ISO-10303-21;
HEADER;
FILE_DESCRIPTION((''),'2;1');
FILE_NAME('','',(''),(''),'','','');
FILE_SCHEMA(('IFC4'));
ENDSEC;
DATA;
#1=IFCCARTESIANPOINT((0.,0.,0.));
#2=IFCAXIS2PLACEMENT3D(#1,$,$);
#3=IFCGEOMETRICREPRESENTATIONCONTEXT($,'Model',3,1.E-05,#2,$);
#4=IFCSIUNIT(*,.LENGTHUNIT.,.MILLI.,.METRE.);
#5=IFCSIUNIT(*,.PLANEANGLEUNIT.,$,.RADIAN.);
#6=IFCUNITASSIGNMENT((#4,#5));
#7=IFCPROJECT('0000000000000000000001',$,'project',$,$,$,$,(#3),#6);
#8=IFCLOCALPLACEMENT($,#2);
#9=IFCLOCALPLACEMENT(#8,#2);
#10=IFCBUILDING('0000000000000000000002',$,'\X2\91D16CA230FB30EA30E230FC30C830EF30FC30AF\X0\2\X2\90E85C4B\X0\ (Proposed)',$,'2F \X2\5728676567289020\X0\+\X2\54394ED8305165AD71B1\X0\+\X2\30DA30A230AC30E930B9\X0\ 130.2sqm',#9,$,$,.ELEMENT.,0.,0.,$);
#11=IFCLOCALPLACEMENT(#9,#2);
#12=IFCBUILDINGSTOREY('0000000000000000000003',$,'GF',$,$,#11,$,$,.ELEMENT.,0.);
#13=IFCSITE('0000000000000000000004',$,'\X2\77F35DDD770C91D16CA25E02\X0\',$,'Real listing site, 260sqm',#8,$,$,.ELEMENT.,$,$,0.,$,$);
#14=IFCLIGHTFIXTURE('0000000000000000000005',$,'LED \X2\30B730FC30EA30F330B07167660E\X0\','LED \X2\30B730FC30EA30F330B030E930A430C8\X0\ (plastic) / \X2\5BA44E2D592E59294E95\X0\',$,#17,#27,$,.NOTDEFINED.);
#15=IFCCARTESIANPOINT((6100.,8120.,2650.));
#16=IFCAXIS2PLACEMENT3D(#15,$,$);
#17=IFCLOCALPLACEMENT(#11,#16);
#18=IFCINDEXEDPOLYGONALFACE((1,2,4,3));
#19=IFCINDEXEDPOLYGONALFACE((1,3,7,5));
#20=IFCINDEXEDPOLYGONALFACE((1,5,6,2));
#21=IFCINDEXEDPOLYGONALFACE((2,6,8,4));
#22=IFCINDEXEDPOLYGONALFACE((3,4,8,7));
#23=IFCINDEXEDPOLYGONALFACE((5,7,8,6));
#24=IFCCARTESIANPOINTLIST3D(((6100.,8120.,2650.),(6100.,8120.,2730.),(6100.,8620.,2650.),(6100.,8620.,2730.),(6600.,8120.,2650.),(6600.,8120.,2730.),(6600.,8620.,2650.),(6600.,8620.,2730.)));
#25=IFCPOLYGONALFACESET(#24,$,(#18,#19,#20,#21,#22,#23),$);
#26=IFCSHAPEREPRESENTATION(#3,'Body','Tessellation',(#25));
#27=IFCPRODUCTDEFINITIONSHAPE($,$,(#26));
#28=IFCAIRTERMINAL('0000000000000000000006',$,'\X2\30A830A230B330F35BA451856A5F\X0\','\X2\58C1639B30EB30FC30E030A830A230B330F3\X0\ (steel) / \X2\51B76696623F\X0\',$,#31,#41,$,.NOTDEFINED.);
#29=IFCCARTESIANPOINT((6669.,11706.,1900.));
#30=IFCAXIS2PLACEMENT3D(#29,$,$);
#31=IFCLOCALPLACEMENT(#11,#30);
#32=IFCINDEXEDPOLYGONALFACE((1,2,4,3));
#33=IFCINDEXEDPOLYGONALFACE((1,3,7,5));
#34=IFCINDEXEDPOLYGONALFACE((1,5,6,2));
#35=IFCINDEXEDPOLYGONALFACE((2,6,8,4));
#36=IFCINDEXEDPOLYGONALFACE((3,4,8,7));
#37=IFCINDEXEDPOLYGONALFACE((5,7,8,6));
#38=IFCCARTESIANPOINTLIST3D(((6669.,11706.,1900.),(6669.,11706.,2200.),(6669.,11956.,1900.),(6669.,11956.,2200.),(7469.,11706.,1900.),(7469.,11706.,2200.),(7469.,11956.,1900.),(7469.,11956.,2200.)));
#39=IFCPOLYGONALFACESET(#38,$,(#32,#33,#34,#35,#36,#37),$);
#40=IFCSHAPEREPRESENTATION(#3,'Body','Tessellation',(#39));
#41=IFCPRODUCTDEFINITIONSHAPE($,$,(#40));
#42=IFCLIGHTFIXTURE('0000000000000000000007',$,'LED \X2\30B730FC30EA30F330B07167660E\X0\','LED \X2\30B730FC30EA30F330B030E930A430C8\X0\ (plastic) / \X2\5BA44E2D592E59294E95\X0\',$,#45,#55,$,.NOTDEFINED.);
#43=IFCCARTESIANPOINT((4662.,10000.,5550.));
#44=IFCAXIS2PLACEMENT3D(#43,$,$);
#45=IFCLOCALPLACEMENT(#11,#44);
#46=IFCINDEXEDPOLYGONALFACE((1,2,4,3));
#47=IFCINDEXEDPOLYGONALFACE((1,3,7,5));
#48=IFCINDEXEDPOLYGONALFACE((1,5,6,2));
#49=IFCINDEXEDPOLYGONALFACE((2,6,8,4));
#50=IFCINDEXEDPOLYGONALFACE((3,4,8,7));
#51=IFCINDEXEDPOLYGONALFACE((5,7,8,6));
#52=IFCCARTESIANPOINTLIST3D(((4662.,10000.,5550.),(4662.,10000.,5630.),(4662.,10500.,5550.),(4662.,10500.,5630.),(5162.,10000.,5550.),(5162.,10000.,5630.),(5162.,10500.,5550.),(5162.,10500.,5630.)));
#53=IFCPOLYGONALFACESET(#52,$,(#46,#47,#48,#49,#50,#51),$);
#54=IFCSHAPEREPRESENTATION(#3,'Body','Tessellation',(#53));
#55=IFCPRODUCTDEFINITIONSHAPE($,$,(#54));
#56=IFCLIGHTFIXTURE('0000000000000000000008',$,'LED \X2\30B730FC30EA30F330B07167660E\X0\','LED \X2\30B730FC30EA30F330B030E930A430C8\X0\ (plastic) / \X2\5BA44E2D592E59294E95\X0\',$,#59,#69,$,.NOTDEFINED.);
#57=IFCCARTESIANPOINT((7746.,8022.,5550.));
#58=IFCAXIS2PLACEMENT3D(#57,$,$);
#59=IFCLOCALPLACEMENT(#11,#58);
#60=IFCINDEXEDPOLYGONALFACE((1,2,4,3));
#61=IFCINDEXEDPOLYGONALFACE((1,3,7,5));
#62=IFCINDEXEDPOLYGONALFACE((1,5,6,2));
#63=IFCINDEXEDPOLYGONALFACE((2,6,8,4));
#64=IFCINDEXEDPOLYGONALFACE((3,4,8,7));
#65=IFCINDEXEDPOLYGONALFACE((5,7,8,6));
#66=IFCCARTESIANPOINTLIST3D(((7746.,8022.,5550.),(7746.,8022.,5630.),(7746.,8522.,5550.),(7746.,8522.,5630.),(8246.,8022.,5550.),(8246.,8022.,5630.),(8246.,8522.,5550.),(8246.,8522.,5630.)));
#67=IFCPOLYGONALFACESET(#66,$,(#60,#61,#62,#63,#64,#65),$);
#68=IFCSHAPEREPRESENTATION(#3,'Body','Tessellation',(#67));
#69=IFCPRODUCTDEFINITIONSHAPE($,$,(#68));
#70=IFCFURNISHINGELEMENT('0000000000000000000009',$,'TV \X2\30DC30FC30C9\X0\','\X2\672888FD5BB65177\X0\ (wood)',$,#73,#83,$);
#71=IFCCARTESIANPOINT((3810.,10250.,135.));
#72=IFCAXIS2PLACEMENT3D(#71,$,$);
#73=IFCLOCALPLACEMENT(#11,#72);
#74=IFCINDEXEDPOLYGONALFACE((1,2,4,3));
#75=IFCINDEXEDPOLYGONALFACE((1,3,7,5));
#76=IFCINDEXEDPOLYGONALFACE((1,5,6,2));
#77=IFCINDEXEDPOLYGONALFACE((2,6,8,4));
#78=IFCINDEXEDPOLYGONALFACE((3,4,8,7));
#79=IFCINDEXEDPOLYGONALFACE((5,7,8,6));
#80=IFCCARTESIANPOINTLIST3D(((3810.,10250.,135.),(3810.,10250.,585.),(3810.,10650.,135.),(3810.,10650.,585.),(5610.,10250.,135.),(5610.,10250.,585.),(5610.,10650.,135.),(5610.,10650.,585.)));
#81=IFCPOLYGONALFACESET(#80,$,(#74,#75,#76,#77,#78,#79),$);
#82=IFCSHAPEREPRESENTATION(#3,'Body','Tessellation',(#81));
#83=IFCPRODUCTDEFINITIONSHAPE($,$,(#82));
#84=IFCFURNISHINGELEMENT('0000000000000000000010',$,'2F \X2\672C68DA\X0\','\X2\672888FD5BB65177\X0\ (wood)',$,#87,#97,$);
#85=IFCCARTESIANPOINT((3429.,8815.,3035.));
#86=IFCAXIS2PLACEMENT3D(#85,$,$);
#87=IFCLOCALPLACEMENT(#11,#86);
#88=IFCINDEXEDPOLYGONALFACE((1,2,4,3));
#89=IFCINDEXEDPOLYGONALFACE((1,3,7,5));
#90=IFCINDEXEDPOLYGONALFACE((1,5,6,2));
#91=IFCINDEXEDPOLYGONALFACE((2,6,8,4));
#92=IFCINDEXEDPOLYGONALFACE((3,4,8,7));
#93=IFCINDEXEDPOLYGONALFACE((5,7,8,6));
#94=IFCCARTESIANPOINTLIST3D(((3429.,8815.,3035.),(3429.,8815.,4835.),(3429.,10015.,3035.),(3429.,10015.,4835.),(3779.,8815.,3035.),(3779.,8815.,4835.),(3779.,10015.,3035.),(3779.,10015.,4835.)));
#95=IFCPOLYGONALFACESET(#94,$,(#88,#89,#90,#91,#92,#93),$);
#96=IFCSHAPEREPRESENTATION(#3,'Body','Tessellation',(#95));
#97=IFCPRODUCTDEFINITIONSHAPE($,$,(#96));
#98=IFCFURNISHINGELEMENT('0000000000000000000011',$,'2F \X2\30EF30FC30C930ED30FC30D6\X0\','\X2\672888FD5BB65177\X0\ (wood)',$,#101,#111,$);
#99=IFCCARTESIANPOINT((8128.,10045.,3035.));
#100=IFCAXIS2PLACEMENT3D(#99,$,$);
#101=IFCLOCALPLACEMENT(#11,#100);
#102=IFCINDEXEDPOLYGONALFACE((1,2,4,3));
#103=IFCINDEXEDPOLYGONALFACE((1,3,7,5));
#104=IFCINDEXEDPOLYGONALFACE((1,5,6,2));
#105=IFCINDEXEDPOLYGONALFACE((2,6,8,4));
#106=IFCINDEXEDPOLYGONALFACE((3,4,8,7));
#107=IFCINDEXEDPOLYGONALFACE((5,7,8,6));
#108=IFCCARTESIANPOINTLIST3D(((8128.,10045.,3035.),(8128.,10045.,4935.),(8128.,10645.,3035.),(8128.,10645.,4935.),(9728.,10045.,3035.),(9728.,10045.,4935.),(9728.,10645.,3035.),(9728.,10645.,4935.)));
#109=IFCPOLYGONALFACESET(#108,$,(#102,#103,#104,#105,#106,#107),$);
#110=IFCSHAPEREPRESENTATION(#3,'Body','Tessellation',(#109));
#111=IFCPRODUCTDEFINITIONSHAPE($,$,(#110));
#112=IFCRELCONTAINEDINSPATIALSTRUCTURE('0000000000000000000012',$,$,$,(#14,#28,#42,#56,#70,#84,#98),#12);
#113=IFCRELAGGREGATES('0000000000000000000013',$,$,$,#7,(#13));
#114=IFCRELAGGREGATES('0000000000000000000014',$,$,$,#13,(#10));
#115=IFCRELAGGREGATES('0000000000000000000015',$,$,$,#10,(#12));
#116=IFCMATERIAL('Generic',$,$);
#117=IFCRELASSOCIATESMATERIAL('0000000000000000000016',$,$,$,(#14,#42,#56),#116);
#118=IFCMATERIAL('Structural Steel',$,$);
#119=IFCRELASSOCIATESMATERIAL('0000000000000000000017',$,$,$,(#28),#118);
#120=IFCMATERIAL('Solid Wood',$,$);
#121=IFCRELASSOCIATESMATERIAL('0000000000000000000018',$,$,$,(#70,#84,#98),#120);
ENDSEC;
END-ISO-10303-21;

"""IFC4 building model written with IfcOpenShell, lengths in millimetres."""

from ifc_helpers import new_model, si_unit, frame, frame_2d, origin, place, context, project, spatial, rectangle, extrude, material, element, save


model = new_model("IFC4")

# Units and contexts
model_context = context("Model", 3, precision=1e-05, world=origin())
ifc_project = project(units=[si_unit("LENGTHUNIT", "METRE", prefix="MILLI"), si_unit("PLANEANGLEUNIT", "RADIAN")], contexts=[model_context])

# Site, building, storey
site_placement = place(None, origin())
site = spatial("IfcSite", under=ifc_project, at=site_placement, Name="石川県金沢市", ObjectType="Real listing site, 260sqm", CompositionType="ELEMENT", RefElevation=0.0)
building_placement = place(site_placement, origin())
building = spatial("IfcBuilding", under=site, at=building_placement, Name="金沢・リモートワーク2部屋 (Proposed)", ObjectType="2F 在来木造+吹付け断熱+ペアガラス 130.2sqm", CompositionType="ELEMENT", ElevationOfRefHeight=0.0, ElevationOfTerrain=0.0)
storey_placement = place(building_placement, origin())
storey = spatial("IfcBuildingStorey", under=building, at=storey_placement, Name="GF", CompositionType="ELEMENT", Elevation=0.0)

# Shared definitions
ifc_material_1 = material(Name="Solid Wood")

# Shared definitions
ifc_material_2 = material(Name="Structural Steel")

# Shared definitions
ifc_material_3 = material(Name="Generic")

# Light fixture
light_fixture_1_placement = place(storey_placement, frame((6100.0, 8120.0, 2650.0)))
element("IfcLightFixture", 1, at=light_fixture_1_placement, inside=storey, material=ifc_material_3, Name="LED シーリング照明", Description="LED シーリングライト (plastic) / 室中央天井", PredefinedType="NOTDEFINED", context=model_context, shape_type="SweptSolid", body=[
    extrude(rectangle(XDim=500.0, YDim=500.0, at=frame_2d((250.0, 250.0))), frame((6100.0, 8120.0, 2650.0)), (0.0, 0.0, 1.0), 80.0),
])

# Air terminal
air_terminal_placement = place(storey_placement, frame((6669.0, 11706.0, 1900.0)))
element("IfcAirTerminal", 2, at=air_terminal_placement, inside=storey, material=ifc_material_2, Name="エアコン室内機", Description="壁掛ルームエアコン (steel) / 冷暖房", PredefinedType="NOTDEFINED", context=model_context, shape_type="SweptSolid", body=[
    extrude(rectangle(XDim=800.0, YDim=250.0, at=frame_2d((400.0, 125.0))), frame((6669.0, 11706.0, 1900.0)), (0.0, 0.0, 1.0), 300.0),
])

# Light fixtures
light_fixture_2_placement = place(storey_placement, frame((4662.0, 10000.0, 5550.0)))
element("IfcLightFixture", 3, at=light_fixture_2_placement, inside=storey, material=ifc_material_3, Name="LED シーリング照明", Description="LED シーリングライト (plastic) / 室中央天井", PredefinedType="NOTDEFINED", context=model_context, shape_type="SweptSolid", body=[
    extrude(rectangle(XDim=500.0, YDim=500.0, at=frame_2d((250.0, 250.0))), frame((4662.0, 10000.0, 5550.0)), (0.0, 0.0, 1.0), 80.0),
])
light_fixture_3_placement = place(storey_placement, frame((7746.0, 8022.0, 5550.0)))
element("IfcLightFixture", 4, at=light_fixture_3_placement, inside=storey, material=ifc_material_3, Name="LED シーリング照明", Description="LED シーリングライト (plastic) / 室中央天井", PredefinedType="NOTDEFINED", context=model_context, shape_type="SweptSolid", body=[
    extrude(rectangle(XDim=500.0, YDim=500.0, at=frame_2d((250.0, 250.0))), frame((7746.0, 8022.0, 5550.0)), (0.0, 0.0, 1.0), 80.0),
])

# Furnishing elements
furnishing_1_placement = place(storey_placement, frame((3810.0, 10250.0, 135.0)))
element("IfcFurnishingElement", 5, at=furnishing_1_placement, inside=storey, material=ifc_material_1, Name="TV ボード", Description="木製家具 (wood)", context=model_context, shape_type="SweptSolid", body=[
    extrude(rectangle(XDim=1800.0, YDim=400.0, at=frame_2d((900.0, 200.0))), frame((3810.0, 10250.0, 135.0)), (0.0, 0.0, 1.0), 450.0),
])
furnishing_2_placement = place(storey_placement, frame((3429.0, 8815.0, 3035.0)))
element("IfcFurnishingElement", 6, at=furnishing_2_placement, inside=storey, material=ifc_material_1, Name="2F 本棚", Description="木製家具 (wood)", context=model_context, shape_type="SweptSolid", body=[
    extrude(rectangle(XDim=350.0, YDim=1200.0, at=frame_2d((175.0, 600.0))), frame((3429.0, 8815.0, 3035.0)), (0.0, 0.0, 1.0), 1800.0),
])
furnishing_3_placement = place(storey_placement, frame((8128.0, 10045.0, 3035.0)))
element("IfcFurnishingElement", 7, at=furnishing_3_placement, inside=storey, material=ifc_material_1, Name="2F ワードローブ", Description="木製家具 (wood)", context=model_context, shape_type="SweptSolid", body=[
    extrude(rectangle(XDim=1600.0, YDim=600.0, at=frame_2d((800.0, 300.0))), frame((8128.0, 10045.0, 3035.0)), (0.0, 0.0, 1.0), 1900.0),
])

save(model, "model.ifc")
